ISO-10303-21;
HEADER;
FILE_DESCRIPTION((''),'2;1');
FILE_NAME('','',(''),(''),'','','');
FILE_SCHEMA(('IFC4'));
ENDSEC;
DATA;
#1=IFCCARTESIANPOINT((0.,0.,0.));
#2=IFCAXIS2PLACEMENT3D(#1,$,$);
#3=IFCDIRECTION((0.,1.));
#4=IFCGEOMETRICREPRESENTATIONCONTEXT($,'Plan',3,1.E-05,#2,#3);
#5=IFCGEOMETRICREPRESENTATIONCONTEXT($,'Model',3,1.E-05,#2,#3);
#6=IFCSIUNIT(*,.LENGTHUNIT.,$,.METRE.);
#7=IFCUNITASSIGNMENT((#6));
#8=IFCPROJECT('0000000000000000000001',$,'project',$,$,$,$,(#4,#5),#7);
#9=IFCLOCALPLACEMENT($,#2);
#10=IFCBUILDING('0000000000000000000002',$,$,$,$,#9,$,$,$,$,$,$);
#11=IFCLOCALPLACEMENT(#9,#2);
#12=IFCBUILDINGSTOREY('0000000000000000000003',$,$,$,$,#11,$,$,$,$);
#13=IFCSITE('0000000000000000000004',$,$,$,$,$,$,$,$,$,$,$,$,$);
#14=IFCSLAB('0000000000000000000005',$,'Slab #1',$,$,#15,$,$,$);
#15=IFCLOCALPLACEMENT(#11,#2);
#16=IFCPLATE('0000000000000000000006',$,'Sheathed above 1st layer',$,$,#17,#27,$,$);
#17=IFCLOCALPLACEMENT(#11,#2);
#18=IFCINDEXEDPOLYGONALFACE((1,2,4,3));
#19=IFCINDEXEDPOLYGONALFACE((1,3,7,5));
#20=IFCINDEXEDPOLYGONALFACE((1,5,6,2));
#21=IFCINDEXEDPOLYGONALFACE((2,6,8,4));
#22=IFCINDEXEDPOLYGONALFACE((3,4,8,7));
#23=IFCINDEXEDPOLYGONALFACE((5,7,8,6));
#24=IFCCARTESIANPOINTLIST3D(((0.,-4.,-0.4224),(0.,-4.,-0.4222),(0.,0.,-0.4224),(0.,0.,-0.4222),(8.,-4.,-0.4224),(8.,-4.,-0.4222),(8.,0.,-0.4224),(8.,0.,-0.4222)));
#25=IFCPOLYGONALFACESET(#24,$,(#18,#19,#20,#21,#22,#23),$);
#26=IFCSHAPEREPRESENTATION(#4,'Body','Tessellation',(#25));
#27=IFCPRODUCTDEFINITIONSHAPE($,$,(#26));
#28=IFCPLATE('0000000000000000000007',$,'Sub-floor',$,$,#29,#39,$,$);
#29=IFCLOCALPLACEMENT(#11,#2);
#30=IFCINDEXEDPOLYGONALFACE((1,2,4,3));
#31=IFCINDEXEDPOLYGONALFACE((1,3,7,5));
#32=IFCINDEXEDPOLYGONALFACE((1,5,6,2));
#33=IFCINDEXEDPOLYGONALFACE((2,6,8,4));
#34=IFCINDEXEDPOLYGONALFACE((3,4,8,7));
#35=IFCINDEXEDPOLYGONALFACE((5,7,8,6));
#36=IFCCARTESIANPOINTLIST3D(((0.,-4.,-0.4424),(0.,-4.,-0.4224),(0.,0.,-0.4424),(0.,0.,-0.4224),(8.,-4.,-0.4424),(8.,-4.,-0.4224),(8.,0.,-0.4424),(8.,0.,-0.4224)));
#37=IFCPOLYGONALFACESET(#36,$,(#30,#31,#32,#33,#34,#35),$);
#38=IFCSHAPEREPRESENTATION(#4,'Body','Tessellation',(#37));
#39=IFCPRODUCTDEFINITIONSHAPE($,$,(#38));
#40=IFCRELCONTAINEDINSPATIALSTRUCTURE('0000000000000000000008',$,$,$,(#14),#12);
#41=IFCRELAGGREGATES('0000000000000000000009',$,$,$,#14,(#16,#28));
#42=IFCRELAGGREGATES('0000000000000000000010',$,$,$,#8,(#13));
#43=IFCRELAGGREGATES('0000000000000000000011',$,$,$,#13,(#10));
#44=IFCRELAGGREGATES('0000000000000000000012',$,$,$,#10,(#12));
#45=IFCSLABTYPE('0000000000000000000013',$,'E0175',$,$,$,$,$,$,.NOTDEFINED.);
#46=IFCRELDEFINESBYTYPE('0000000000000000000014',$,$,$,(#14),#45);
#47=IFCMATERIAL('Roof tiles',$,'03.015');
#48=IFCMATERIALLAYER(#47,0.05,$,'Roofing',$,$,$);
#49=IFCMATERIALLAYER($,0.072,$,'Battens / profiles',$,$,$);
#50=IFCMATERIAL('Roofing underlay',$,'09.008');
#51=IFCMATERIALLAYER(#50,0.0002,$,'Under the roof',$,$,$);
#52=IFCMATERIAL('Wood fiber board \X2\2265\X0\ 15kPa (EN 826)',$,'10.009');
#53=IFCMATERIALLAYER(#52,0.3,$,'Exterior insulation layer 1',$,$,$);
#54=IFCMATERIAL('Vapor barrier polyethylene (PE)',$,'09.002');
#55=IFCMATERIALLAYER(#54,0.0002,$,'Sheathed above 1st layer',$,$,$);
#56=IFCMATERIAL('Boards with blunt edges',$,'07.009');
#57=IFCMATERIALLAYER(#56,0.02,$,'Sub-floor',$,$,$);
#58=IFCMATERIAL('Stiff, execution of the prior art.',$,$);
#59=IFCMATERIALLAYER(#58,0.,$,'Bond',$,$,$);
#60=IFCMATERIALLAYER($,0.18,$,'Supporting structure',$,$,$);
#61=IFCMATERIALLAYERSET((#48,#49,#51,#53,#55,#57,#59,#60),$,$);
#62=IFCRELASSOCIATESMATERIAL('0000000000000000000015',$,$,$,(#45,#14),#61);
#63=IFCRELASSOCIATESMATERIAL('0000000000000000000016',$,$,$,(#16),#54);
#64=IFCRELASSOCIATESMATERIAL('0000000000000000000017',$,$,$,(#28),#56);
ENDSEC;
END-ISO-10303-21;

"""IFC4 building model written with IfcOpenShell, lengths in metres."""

from ifc_helpers import new_model, si_unit, direction, frame, frame_2d, origin, place, context, project, spatial, rectangle, extrude, material, layer, layer_set, type_object, element, aggregate, save


model = new_model("IFC4")

# Units and contexts
plan_context = context("Plan", 3, precision=1e-05, world=origin(), true_north=direction((0.0, 1.0)))
model_context = context("Model", 3, precision=1e-05, world=origin(), true_north=direction((0.0, 1.0)))
ifc_project = project(units=[si_unit("LENGTHUNIT", "METRE")], contexts=[plan_context, model_context])

# Site, building, storey
site = spatial("IfcSite", under=ifc_project)
building_placement = place(None, origin())
building = spatial("IfcBuilding", under=site, at=building_placement)
storey_placement = place(building_placement, origin())
storey = spatial("IfcBuildingStorey", under=building, at=storey_placement)

# Slab, plates
ifc_material_1 = material(Name="Roof tiles", Category="03.015")
ifc_layer_1 = layer(ifc_material_1, 0.05, Name="Roofing")
ifc_layer_2 = layer(None, 0.072, Name="Battens / profiles")
ifc_material_2 = material(Name="Roofing underlay", Category="09.008")
ifc_layer_3 = layer(ifc_material_2, 0.0002, Name="Under the roof")
ifc_material_3 = material(Name="Wood fiber board ≥ 15kPa (EN 826)", Category="10.009")
ifc_layer_4 = layer(ifc_material_3, 0.3, Name="Exterior insulation layer 1")
ifc_material_4 = material(Name="Vapor barrier polyethylene (PE)", Category="09.002")
ifc_layer_5 = layer(ifc_material_4, 0.0002, Name="Sheathed above 1st layer")
ifc_material_5 = material(Name="Boards with blunt edges", Category="07.009")
ifc_layer_6 = layer(ifc_material_5, 0.02, Name="Sub-floor")
ifc_material_6 = material(Name="Stiff, execution of the prior art.")
ifc_layer_7 = layer(ifc_material_6, 0.0, Name="Bond")
ifc_layer_8 = layer(None, 0.18, Name="Supporting structure")
ifc_layer_set = layer_set([ifc_layer_1, ifc_layer_2, ifc_layer_3, ifc_layer_4, ifc_layer_5, ifc_layer_6, ifc_layer_7, ifc_layer_8])
slab_type = type_object("IfcSlabType", Name="E0175", PredefinedType="NOTDEFINED", material=ifc_layer_set)
slab_placement = place(None, frame((0.0, 0.0, 0.0), z_axis=(0.0, 0.0, -1.0), x_axis=(1.0, 0.0, 0.0)))
slab = element("IfcSlab", 1, at=slab_placement, inside=storey, type_object=slab_type, material=ifc_layer_set, Name="Slab #1")
plate_1_placement = place(slab_placement, origin())
plate_1 = element("IfcPlate", 2, at=plate_1_placement, material=ifc_material_4, Name="Sheathed above 1st layer", context=plan_context, shape_type="SweptSolid", body=[
    extrude(rectangle(XDim=8.0, YDim=4.0, at=frame_2d((4.0, 2.0), x_axis=(1.0, 0.0))), frame((0.0, 0.0, 0.4222), z_axis=(0.0, 0.0, 1.0), x_axis=(1.0, 0.0, 0.0)), (0.0, 0.0, 1.0), 0.0002),
])
plate_2_placement = place(slab_placement, origin())
plate_2 = element("IfcPlate", 3, at=plate_2_placement, material=ifc_material_5, Name="Sub-floor", context=plan_context, shape_type="SweptSolid", body=[
    extrude(rectangle(XDim=8.0, YDim=4.0, at=frame_2d((4.0, 2.0), x_axis=(1.0, 0.0))), frame((0.0, 0.0, 0.4224), z_axis=(0.0, 0.0, 1.0), x_axis=(1.0, 0.0, 0.0)), (0.0, 0.0, 1.0), 0.02),
])
aggregate(slab, [plate_1, plate_2])

save(model, "model.ifc")
